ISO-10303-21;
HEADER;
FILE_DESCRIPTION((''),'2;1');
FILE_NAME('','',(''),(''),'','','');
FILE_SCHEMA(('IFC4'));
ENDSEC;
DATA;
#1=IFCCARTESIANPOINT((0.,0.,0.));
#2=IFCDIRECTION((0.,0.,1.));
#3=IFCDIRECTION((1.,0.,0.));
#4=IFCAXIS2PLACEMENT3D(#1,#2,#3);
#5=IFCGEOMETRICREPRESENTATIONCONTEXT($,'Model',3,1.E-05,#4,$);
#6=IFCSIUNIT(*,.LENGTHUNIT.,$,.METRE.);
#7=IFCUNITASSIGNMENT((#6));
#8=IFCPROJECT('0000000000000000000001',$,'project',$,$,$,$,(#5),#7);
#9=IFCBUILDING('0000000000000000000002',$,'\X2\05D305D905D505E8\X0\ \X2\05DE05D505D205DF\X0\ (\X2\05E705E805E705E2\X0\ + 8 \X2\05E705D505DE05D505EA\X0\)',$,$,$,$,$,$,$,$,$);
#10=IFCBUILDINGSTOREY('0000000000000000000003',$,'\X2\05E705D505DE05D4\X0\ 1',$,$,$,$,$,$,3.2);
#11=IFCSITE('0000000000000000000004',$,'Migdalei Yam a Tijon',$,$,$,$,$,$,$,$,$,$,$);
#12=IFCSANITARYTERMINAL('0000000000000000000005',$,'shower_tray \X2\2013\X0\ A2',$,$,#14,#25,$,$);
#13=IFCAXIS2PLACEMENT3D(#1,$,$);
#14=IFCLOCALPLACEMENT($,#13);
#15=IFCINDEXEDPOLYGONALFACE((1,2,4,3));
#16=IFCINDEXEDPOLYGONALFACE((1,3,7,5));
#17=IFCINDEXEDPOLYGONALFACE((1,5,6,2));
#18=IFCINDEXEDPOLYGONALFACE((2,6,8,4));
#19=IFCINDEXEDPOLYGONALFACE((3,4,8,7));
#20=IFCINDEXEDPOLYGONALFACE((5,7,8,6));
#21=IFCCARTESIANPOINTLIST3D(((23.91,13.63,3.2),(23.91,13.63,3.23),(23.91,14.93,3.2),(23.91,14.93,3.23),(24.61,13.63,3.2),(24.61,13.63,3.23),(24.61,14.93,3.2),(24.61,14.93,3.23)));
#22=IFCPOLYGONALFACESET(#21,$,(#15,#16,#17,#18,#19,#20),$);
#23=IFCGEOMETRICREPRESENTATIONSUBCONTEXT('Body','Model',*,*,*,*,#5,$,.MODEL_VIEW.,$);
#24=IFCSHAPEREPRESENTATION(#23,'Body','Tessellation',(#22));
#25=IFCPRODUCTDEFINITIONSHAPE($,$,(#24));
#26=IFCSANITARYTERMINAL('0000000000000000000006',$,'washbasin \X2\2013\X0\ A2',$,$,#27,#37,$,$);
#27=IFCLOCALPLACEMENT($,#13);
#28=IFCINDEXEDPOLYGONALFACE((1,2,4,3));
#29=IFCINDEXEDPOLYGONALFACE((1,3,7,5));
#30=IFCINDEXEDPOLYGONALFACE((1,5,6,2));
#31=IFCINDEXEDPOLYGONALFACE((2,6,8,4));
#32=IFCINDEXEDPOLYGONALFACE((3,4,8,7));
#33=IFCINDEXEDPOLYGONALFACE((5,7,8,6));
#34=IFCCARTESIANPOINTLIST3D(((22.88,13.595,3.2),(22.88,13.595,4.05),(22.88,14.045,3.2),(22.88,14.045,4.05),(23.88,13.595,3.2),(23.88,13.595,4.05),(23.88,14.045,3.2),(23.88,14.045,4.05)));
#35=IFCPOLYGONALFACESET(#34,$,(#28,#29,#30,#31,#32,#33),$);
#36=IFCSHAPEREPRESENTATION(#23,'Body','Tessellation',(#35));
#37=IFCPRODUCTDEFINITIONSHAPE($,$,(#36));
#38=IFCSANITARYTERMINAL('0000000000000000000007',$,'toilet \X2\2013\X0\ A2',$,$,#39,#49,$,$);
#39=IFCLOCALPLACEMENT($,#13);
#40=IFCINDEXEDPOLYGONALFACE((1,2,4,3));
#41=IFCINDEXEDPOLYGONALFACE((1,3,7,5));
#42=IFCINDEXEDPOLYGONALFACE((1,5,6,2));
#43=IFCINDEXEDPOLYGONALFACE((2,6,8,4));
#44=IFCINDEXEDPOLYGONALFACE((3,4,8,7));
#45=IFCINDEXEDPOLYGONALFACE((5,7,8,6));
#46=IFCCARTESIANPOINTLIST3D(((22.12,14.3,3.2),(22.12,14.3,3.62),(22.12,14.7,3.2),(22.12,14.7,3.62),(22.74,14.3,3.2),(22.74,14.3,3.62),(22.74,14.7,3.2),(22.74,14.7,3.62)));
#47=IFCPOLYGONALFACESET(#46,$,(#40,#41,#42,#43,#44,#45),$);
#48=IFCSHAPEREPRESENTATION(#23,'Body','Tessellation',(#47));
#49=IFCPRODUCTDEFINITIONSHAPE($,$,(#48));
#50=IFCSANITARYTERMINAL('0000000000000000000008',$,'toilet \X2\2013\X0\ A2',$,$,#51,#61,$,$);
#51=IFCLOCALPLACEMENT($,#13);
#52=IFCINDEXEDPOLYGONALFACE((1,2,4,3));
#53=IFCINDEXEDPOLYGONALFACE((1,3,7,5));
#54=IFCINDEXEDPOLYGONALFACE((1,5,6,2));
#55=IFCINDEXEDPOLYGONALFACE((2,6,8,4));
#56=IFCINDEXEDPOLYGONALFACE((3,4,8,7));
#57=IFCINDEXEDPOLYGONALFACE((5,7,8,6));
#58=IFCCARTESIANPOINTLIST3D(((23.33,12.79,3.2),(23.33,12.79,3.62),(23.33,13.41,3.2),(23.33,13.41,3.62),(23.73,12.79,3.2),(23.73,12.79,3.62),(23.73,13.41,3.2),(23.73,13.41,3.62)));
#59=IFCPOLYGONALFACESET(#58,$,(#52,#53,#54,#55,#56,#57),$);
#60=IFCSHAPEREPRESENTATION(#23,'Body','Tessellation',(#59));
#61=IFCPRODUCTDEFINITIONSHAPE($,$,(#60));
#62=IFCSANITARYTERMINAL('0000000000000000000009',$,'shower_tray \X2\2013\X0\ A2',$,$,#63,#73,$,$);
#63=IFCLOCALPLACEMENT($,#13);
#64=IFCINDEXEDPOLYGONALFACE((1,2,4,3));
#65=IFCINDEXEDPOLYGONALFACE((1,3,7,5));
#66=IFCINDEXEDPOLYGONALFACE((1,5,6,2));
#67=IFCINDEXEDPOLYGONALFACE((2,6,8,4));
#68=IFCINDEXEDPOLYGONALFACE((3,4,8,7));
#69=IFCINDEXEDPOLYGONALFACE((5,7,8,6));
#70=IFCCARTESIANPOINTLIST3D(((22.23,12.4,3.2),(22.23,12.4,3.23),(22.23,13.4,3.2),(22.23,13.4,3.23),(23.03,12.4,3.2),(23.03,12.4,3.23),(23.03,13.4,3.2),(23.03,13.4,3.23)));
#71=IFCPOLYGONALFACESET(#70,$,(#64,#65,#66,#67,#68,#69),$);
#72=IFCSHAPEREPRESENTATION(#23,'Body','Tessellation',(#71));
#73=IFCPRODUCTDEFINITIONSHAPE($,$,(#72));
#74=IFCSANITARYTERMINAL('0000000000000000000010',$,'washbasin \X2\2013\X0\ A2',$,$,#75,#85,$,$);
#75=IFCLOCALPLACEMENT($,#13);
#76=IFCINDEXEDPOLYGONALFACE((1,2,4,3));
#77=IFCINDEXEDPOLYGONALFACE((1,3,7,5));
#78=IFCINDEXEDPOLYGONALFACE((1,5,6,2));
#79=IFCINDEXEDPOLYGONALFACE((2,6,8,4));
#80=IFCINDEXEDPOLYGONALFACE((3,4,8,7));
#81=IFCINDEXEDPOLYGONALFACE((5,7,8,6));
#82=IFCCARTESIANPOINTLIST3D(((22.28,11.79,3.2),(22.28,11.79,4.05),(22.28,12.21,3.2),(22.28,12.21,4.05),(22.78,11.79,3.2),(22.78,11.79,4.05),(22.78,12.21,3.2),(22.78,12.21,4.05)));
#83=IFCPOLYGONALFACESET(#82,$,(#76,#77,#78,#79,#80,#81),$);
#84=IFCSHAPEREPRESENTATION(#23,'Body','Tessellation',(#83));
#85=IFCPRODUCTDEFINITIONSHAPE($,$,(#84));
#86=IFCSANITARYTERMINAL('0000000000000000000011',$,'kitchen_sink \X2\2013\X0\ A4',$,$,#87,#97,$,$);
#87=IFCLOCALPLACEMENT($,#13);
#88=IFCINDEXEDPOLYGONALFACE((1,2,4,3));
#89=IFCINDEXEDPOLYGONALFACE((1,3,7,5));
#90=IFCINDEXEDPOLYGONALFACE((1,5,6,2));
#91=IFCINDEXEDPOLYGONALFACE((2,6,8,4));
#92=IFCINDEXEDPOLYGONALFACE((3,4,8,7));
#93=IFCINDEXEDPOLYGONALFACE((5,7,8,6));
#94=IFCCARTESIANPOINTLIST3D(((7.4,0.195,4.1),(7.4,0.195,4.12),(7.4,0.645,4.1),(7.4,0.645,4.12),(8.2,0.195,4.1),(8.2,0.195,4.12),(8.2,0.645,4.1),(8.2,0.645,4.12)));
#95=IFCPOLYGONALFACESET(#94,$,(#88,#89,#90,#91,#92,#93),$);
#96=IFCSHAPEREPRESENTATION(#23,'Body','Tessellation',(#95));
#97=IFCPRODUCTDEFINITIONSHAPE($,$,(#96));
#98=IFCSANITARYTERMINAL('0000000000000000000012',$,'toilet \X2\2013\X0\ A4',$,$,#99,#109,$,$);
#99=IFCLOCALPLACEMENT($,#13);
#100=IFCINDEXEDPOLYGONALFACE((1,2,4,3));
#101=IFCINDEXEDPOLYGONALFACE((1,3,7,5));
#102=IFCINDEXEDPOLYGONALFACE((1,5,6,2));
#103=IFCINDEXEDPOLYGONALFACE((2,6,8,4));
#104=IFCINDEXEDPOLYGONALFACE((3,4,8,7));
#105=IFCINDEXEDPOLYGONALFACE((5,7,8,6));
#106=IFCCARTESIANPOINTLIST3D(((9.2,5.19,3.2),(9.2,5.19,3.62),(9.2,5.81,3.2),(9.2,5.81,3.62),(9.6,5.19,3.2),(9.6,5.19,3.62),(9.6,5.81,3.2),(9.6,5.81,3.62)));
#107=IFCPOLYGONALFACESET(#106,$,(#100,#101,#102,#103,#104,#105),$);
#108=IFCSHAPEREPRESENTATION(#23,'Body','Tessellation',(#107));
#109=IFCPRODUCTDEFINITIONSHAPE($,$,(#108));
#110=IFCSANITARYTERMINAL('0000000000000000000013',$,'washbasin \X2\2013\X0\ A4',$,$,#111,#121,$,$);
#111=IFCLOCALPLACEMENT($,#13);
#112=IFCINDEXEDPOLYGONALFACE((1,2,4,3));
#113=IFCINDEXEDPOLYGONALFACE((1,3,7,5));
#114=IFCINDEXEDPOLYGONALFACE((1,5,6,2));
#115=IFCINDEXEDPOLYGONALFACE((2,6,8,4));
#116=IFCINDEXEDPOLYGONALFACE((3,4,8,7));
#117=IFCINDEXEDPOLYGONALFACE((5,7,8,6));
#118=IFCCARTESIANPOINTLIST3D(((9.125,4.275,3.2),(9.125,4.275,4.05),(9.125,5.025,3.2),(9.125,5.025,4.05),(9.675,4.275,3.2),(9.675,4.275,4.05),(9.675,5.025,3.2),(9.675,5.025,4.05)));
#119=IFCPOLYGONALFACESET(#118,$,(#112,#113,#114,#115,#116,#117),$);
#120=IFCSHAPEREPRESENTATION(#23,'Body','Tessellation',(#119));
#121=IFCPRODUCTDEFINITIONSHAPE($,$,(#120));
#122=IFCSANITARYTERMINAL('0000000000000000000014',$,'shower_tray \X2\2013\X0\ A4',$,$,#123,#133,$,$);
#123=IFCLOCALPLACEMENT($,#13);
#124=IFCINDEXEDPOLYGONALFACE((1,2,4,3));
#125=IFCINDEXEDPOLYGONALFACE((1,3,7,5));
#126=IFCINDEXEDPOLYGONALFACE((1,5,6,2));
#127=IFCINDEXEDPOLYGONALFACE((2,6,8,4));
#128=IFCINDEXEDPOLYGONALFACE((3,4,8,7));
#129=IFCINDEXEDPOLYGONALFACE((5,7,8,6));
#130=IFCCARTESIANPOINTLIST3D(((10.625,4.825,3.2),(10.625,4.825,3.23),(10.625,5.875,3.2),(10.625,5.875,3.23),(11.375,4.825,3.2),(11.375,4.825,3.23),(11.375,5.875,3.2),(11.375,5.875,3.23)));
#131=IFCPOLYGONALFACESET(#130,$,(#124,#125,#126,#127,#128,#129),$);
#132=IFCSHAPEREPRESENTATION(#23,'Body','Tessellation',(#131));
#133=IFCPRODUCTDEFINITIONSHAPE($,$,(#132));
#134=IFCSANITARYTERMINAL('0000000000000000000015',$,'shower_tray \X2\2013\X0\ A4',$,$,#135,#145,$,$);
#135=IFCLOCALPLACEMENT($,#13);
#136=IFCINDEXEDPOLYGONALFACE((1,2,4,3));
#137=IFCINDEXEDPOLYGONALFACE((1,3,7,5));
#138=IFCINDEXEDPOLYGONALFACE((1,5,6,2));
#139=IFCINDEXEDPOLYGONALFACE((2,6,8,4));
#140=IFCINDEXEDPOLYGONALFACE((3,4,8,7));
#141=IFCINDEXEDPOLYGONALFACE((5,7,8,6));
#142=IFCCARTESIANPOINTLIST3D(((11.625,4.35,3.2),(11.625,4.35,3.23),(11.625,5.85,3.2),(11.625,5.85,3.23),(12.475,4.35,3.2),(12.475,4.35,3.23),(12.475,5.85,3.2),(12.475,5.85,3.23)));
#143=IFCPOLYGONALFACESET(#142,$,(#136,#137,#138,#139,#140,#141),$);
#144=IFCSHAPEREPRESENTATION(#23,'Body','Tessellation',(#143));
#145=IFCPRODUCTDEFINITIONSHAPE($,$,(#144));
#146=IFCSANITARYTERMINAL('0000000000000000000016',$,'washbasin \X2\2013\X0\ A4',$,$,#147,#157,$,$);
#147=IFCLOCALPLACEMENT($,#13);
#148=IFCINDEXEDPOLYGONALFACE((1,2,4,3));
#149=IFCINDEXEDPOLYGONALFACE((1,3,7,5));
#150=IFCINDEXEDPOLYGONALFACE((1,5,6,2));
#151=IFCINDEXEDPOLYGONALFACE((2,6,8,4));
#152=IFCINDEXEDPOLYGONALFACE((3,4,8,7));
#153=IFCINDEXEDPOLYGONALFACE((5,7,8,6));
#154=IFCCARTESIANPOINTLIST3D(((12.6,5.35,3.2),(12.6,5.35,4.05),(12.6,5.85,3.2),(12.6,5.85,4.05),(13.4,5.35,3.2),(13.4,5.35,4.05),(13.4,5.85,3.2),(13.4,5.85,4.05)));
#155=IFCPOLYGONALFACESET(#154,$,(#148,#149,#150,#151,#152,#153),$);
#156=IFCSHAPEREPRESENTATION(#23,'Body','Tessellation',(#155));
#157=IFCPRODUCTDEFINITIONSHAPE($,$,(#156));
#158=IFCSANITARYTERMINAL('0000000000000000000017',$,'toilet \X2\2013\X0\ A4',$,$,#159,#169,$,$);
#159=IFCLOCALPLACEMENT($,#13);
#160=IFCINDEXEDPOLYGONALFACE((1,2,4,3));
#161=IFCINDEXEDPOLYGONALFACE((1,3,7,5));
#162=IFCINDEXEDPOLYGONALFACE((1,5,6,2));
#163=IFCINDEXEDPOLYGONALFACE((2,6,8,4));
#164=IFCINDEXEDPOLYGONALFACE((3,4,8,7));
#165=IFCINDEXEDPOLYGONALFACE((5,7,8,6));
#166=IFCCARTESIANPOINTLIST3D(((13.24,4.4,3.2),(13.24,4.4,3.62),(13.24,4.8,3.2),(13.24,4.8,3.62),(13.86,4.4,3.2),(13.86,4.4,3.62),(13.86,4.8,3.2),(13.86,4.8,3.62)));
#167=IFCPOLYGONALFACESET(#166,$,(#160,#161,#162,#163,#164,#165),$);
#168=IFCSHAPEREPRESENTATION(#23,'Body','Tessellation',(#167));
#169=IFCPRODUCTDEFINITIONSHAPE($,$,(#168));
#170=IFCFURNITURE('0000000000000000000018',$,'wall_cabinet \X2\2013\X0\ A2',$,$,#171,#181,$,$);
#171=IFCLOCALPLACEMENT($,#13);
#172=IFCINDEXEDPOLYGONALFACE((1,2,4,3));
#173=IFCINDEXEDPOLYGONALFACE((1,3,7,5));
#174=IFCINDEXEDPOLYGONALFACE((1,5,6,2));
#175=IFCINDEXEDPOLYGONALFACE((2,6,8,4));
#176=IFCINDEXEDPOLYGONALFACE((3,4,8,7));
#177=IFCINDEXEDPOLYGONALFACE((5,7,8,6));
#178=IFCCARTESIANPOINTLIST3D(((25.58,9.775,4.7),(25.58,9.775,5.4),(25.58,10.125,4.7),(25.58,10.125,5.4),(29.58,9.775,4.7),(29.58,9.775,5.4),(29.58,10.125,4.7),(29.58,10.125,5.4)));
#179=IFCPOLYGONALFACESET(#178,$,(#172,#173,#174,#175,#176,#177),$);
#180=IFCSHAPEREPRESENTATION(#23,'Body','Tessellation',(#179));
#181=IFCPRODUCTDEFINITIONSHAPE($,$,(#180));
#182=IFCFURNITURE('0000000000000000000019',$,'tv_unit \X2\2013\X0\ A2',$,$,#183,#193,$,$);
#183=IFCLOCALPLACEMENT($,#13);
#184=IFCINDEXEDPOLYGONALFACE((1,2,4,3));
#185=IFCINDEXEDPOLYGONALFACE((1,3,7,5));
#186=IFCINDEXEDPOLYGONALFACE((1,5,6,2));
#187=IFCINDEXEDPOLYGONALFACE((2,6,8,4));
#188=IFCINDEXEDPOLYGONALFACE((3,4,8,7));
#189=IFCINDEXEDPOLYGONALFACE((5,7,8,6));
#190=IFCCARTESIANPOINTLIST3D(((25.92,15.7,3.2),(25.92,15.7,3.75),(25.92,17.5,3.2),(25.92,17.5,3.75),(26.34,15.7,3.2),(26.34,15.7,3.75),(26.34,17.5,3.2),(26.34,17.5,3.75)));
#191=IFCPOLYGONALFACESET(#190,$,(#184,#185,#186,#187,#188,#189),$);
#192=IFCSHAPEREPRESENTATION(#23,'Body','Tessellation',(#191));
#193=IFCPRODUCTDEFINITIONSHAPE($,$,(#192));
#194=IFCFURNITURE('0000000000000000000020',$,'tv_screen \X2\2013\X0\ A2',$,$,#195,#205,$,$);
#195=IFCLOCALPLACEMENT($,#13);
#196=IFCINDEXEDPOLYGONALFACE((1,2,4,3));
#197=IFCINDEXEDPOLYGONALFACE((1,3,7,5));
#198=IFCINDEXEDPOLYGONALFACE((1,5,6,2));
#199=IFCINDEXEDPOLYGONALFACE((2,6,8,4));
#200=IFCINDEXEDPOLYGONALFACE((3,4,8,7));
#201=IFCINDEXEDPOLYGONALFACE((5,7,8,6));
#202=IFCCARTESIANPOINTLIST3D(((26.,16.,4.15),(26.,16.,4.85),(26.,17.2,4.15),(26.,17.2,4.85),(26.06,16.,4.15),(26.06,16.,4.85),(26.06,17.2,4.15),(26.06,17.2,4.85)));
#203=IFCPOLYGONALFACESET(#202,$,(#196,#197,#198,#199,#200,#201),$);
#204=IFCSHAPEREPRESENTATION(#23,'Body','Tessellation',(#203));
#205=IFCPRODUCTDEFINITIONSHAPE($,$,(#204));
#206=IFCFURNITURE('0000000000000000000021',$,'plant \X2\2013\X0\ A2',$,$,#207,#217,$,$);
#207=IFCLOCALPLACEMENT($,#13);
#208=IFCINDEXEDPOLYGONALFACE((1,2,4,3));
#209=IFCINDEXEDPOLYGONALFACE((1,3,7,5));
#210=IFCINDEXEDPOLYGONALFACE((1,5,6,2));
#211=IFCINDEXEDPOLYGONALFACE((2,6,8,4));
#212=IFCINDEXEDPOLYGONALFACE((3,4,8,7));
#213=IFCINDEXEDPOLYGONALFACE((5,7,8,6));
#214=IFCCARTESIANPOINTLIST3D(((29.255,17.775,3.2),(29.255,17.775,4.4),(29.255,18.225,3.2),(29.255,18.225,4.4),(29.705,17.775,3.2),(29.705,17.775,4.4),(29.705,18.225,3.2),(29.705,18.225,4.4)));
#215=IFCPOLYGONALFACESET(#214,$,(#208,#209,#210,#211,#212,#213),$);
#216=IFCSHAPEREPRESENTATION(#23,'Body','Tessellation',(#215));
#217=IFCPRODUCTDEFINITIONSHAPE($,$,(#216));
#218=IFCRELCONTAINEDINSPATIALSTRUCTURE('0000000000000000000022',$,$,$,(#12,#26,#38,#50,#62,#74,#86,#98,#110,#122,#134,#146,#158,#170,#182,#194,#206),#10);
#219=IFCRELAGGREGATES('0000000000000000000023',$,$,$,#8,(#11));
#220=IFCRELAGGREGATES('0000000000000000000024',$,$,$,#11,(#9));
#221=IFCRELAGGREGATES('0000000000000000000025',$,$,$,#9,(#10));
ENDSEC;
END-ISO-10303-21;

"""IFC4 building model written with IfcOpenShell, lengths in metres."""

from ifc_helpers import new_model, si_unit, frame, origin_with_axes, context, subcontext, project, spatial, line, indexed_curve, outline, extrude, element, save


model = new_model("IFC4")

# Units and contexts
model_context = context("Model", 3, precision=1e-05, world=origin_with_axes())
body_context = subcontext(model_context, "Body", "Model", "MODEL_VIEW")
ifc_project = project(units=[si_unit("LENGTHUNIT", "METRE")], contexts=[model_context])

# Site, building, storey
site = spatial("IfcSite", under=ifc_project, Name="Migdalei Yam a Tijon")
building = spatial("IfcBuilding", under=site, Name="דיור מוגן (קרקע + 8 קומות)")
storey = spatial("IfcBuildingStorey", under=building, Name="קומה 1", Elevation=3.2)

# Sanitary terminals
element("IfcSanitaryTerminal", 1, inside=storey, Name="shower_tray – A2", context=body_context, shape_type="SweptSolid", body=[
    extrude(outline(indexed_curve([(0.0, 0.0), (0.7, 0.0), (0.7, 1.3), (0.0, 1.3)], segments=[line(1, 2, 3, 4, 1)])), frame((23.91, 13.63, 3.2), z_axis=(0.0, 0.0, 1.0), x_axis=(1.0, 0.0, 0.0)), (0.0, 0.0, 1.0), 0.03),
])
element("IfcSanitaryTerminal", 2, inside=storey, Name="washbasin – A2", context=body_context, shape_type="SweptSolid", body=[
    extrude(outline(indexed_curve([(0.0, 0.0), (1.0, 0.0), (1.0, 0.45), (0.0, 0.45)], segments=[line(1, 2, 3, 4, 1)])), frame((22.88, 13.595, 3.2), z_axis=(0.0, 0.0, 1.0), x_axis=(1.0, 0.0, 0.0)), (0.0, 0.0, 1.0), 0.85),
])
element("IfcSanitaryTerminal", 3, inside=storey, Name="toilet – A2", context=body_context, shape_type="SweptSolid", body=[
    extrude(outline(indexed_curve([(0.0, 0.0), (0.62, 0.0), (0.62, 0.4), (0.0, 0.4)], segments=[line(1, 2, 3, 4, 1)])), frame((22.12, 14.3, 3.2), z_axis=(0.0, 0.0, 1.0), x_axis=(1.0, 0.0, 0.0)), (0.0, 0.0, 1.0), 0.42),
])
element("IfcSanitaryTerminal", 4, inside=storey, Name="toilet – A2", context=body_context, shape_type="SweptSolid", body=[
    extrude(outline(indexed_curve([(0.0, 0.0), (0.4, 0.0), (0.4, 0.62), (0.0, 0.62)], segments=[line(1, 2, 3, 4, 1)])), frame((23.33, 12.79, 3.2), z_axis=(0.0, 0.0, 1.0), x_axis=(1.0, 0.0, 0.0)), (0.0, 0.0, 1.0), 0.42),
])
element("IfcSanitaryTerminal", 5, inside=storey, Name="shower_tray – A2", context=body_context, shape_type="SweptSolid", body=[
    extrude(outline(indexed_curve([(0.0, 0.0), (0.8, 0.0), (0.8, 1.0), (0.0, 1.0)], segments=[line(1, 2, 3, 4, 1)])), frame((22.23, 12.4, 3.2), z_axis=(0.0, 0.0, 1.0), x_axis=(1.0, 0.0, 0.0)), (0.0, 0.0, 1.0), 0.03),
])
element("IfcSanitaryTerminal", 6, inside=storey, Name="washbasin – A2", context=body_context, shape_type="SweptSolid", body=[
    extrude(outline(indexed_curve([(0.0, 0.0), (0.5, 0.0), (0.5, 0.42), (0.0, 0.42)], segments=[line(1, 2, 3, 4, 1)])), frame((22.28, 11.79, 3.2), z_axis=(0.0, 0.0, 1.0), x_axis=(1.0, 0.0, 0.0)), (0.0, 0.0, 1.0), 0.85),
])
element("IfcSanitaryTerminal", 7, inside=storey, Name="kitchen_sink – A4", context=body_context, shape_type="SweptSolid", body=[
    extrude(outline(indexed_curve([(0.0, 0.0), (0.8, 0.0), (0.8, 0.45), (0.0, 0.45)], segments=[line(1, 2, 3, 4, 1)])), frame((7.4, 0.195, 4.1), z_axis=(0.0, 0.0, 1.0), x_axis=(1.0, 0.0, 0.0)), (0.0, 0.0, 1.0), 0.02),
])
element("IfcSanitaryTerminal", 8, inside=storey, Name="toilet – A4", context=body_context, shape_type="SweptSolid", body=[
    extrude(outline(indexed_curve([(0.0, 0.0), (0.4, 0.0), (0.4, 0.62), (0.0, 0.62)], segments=[line(1, 2, 3, 4, 1)])), frame((9.2, 5.19, 3.2), z_axis=(0.0, 0.0, 1.0), x_axis=(1.0, 0.0, 0.0)), (0.0, 0.0, 1.0), 0.42),
])
element("IfcSanitaryTerminal", 9, inside=storey, Name="washbasin – A4", context=body_context, shape_type="SweptSolid", body=[
    extrude(outline(indexed_curve([(0.0, 0.0), (0.55, 0.0), (0.55, 0.75), (0.0, 0.75)], segments=[line(1, 2, 3, 4, 1)])), frame((9.125, 4.275, 3.2), z_axis=(0.0, 0.0, 1.0), x_axis=(1.0, 0.0, 0.0)), (0.0, 0.0, 1.0), 0.85),
])
element("IfcSanitaryTerminal", 10, inside=storey, Name="shower_tray – A4", context=body_context, shape_type="SweptSolid", body=[
    extrude(outline(indexed_curve([(0.0, 0.0), (0.75, 0.0), (0.75, 1.05), (0.0, 1.05)], segments=[line(1, 2, 3, 4, 1)])), frame((10.625, 4.825, 3.2), z_axis=(0.0, 0.0, 1.0), x_axis=(1.0, 0.0, 0.0)), (0.0, 0.0, 1.0), 0.03),
])
element("IfcSanitaryTerminal", 11, inside=storey, Name="shower_tray – A4", context=body_context, shape_type="SweptSolid", body=[
    extrude(outline(indexed_curve([(0.0, 0.0), (0.85, 0.0), (0.85, 1.5), (0.0, 1.5)], segments=[line(1, 2, 3, 4, 1)])), frame((11.625, 4.35, 3.2), z_axis=(0.0, 0.0, 1.0), x_axis=(1.0, 0.0, 0.0)), (0.0, 0.0, 1.0), 0.03),
])
element("IfcSanitaryTerminal", 12, inside=storey, Name="washbasin – A4", context=body_context, shape_type="SweptSolid", body=[
    extrude(outline(indexed_curve([(0.0, 0.0), (0.8, 0.0), (0.8, 0.5), (0.0, 0.5)], segments=[line(1, 2, 3, 4, 1)])), frame((12.6, 5.35, 3.2), z_axis=(0.0, 0.0, 1.0), x_axis=(1.0, 0.0, 0.0)), (0.0, 0.0, 1.0), 0.85),
])
element("IfcSanitaryTerminal", 13, inside=storey, Name="toilet – A4", context=body_context, shape_type="SweptSolid", body=[
    extrude(outline(indexed_curve([(0.0, 0.0), (0.62, 0.0), (0.62, 0.4), (0.0, 0.4)], segments=[line(1, 2, 3, 4, 1)])), frame((13.24, 4.4, 3.2), z_axis=(0.0, 0.0, 1.0), x_axis=(1.0, 0.0, 0.0)), (0.0, 0.0, 1.0), 0.42),
])

# Furniture
element("IfcFurniture", 14, inside=storey, Name="wall_cabinet – A2", context=body_context, shape_type="SweptSolid", body=[
    extrude(outline(indexed_curve([(0.0, 0.0), (4.0, 0.0), (4.0, 0.35), (0.0, 0.35)], segments=[line(1, 2, 3, 4, 1)])), frame((25.58, 9.775, 4.7), z_axis=(0.0, 0.0, 1.0), x_axis=(1.0, 0.0, 0.0)), (0.0, 0.0, 1.0), 0.7),
])
element("IfcFurniture", 15, inside=storey, Name="tv_unit – A2", context=body_context, shape_type="SweptSolid", body=[
    extrude(outline(indexed_curve([(0.0, 0.0), (0.42, 0.0), (0.42, 1.8), (0.0, 1.8)], segments=[line(1, 2, 3, 4, 1)])), frame((25.92, 15.7, 3.2), z_axis=(0.0, 0.0, 1.0), x_axis=(1.0, 0.0, 0.0)), (0.0, 0.0, 1.0), 0.55),
])
element("IfcFurniture", 16, inside=storey, Name="tv_screen – A2", context=body_context, shape_type="SweptSolid", body=[
    extrude(outline(indexed_curve([(0.0, 0.0), (0.06, 0.0), (0.06, 1.2), (0.0, 1.2)], segments=[line(1, 2, 3, 4, 1)])), frame((26.0, 16.0, 4.15), z_axis=(0.0, 0.0, 1.0), x_axis=(1.0, 0.0, 0.0)), (0.0, 0.0, 1.0), 0.7),
])
element("IfcFurniture", 17, inside=storey, Name="plant – A2", context=body_context, shape_type="SweptSolid", body=[
    extrude(outline(indexed_curve([(0.0, 0.0), (0.45, 0.0), (0.45, 0.45), (0.0, 0.45)], segments=[line(1, 2, 3, 4, 1)])), frame((29.255, 17.775, 3.2), z_axis=(0.0, 0.0, 1.0), x_axis=(1.0, 0.0, 0.0)), (0.0, 0.0, 1.0), 1.2),
])

save(model, "model.ifc")
